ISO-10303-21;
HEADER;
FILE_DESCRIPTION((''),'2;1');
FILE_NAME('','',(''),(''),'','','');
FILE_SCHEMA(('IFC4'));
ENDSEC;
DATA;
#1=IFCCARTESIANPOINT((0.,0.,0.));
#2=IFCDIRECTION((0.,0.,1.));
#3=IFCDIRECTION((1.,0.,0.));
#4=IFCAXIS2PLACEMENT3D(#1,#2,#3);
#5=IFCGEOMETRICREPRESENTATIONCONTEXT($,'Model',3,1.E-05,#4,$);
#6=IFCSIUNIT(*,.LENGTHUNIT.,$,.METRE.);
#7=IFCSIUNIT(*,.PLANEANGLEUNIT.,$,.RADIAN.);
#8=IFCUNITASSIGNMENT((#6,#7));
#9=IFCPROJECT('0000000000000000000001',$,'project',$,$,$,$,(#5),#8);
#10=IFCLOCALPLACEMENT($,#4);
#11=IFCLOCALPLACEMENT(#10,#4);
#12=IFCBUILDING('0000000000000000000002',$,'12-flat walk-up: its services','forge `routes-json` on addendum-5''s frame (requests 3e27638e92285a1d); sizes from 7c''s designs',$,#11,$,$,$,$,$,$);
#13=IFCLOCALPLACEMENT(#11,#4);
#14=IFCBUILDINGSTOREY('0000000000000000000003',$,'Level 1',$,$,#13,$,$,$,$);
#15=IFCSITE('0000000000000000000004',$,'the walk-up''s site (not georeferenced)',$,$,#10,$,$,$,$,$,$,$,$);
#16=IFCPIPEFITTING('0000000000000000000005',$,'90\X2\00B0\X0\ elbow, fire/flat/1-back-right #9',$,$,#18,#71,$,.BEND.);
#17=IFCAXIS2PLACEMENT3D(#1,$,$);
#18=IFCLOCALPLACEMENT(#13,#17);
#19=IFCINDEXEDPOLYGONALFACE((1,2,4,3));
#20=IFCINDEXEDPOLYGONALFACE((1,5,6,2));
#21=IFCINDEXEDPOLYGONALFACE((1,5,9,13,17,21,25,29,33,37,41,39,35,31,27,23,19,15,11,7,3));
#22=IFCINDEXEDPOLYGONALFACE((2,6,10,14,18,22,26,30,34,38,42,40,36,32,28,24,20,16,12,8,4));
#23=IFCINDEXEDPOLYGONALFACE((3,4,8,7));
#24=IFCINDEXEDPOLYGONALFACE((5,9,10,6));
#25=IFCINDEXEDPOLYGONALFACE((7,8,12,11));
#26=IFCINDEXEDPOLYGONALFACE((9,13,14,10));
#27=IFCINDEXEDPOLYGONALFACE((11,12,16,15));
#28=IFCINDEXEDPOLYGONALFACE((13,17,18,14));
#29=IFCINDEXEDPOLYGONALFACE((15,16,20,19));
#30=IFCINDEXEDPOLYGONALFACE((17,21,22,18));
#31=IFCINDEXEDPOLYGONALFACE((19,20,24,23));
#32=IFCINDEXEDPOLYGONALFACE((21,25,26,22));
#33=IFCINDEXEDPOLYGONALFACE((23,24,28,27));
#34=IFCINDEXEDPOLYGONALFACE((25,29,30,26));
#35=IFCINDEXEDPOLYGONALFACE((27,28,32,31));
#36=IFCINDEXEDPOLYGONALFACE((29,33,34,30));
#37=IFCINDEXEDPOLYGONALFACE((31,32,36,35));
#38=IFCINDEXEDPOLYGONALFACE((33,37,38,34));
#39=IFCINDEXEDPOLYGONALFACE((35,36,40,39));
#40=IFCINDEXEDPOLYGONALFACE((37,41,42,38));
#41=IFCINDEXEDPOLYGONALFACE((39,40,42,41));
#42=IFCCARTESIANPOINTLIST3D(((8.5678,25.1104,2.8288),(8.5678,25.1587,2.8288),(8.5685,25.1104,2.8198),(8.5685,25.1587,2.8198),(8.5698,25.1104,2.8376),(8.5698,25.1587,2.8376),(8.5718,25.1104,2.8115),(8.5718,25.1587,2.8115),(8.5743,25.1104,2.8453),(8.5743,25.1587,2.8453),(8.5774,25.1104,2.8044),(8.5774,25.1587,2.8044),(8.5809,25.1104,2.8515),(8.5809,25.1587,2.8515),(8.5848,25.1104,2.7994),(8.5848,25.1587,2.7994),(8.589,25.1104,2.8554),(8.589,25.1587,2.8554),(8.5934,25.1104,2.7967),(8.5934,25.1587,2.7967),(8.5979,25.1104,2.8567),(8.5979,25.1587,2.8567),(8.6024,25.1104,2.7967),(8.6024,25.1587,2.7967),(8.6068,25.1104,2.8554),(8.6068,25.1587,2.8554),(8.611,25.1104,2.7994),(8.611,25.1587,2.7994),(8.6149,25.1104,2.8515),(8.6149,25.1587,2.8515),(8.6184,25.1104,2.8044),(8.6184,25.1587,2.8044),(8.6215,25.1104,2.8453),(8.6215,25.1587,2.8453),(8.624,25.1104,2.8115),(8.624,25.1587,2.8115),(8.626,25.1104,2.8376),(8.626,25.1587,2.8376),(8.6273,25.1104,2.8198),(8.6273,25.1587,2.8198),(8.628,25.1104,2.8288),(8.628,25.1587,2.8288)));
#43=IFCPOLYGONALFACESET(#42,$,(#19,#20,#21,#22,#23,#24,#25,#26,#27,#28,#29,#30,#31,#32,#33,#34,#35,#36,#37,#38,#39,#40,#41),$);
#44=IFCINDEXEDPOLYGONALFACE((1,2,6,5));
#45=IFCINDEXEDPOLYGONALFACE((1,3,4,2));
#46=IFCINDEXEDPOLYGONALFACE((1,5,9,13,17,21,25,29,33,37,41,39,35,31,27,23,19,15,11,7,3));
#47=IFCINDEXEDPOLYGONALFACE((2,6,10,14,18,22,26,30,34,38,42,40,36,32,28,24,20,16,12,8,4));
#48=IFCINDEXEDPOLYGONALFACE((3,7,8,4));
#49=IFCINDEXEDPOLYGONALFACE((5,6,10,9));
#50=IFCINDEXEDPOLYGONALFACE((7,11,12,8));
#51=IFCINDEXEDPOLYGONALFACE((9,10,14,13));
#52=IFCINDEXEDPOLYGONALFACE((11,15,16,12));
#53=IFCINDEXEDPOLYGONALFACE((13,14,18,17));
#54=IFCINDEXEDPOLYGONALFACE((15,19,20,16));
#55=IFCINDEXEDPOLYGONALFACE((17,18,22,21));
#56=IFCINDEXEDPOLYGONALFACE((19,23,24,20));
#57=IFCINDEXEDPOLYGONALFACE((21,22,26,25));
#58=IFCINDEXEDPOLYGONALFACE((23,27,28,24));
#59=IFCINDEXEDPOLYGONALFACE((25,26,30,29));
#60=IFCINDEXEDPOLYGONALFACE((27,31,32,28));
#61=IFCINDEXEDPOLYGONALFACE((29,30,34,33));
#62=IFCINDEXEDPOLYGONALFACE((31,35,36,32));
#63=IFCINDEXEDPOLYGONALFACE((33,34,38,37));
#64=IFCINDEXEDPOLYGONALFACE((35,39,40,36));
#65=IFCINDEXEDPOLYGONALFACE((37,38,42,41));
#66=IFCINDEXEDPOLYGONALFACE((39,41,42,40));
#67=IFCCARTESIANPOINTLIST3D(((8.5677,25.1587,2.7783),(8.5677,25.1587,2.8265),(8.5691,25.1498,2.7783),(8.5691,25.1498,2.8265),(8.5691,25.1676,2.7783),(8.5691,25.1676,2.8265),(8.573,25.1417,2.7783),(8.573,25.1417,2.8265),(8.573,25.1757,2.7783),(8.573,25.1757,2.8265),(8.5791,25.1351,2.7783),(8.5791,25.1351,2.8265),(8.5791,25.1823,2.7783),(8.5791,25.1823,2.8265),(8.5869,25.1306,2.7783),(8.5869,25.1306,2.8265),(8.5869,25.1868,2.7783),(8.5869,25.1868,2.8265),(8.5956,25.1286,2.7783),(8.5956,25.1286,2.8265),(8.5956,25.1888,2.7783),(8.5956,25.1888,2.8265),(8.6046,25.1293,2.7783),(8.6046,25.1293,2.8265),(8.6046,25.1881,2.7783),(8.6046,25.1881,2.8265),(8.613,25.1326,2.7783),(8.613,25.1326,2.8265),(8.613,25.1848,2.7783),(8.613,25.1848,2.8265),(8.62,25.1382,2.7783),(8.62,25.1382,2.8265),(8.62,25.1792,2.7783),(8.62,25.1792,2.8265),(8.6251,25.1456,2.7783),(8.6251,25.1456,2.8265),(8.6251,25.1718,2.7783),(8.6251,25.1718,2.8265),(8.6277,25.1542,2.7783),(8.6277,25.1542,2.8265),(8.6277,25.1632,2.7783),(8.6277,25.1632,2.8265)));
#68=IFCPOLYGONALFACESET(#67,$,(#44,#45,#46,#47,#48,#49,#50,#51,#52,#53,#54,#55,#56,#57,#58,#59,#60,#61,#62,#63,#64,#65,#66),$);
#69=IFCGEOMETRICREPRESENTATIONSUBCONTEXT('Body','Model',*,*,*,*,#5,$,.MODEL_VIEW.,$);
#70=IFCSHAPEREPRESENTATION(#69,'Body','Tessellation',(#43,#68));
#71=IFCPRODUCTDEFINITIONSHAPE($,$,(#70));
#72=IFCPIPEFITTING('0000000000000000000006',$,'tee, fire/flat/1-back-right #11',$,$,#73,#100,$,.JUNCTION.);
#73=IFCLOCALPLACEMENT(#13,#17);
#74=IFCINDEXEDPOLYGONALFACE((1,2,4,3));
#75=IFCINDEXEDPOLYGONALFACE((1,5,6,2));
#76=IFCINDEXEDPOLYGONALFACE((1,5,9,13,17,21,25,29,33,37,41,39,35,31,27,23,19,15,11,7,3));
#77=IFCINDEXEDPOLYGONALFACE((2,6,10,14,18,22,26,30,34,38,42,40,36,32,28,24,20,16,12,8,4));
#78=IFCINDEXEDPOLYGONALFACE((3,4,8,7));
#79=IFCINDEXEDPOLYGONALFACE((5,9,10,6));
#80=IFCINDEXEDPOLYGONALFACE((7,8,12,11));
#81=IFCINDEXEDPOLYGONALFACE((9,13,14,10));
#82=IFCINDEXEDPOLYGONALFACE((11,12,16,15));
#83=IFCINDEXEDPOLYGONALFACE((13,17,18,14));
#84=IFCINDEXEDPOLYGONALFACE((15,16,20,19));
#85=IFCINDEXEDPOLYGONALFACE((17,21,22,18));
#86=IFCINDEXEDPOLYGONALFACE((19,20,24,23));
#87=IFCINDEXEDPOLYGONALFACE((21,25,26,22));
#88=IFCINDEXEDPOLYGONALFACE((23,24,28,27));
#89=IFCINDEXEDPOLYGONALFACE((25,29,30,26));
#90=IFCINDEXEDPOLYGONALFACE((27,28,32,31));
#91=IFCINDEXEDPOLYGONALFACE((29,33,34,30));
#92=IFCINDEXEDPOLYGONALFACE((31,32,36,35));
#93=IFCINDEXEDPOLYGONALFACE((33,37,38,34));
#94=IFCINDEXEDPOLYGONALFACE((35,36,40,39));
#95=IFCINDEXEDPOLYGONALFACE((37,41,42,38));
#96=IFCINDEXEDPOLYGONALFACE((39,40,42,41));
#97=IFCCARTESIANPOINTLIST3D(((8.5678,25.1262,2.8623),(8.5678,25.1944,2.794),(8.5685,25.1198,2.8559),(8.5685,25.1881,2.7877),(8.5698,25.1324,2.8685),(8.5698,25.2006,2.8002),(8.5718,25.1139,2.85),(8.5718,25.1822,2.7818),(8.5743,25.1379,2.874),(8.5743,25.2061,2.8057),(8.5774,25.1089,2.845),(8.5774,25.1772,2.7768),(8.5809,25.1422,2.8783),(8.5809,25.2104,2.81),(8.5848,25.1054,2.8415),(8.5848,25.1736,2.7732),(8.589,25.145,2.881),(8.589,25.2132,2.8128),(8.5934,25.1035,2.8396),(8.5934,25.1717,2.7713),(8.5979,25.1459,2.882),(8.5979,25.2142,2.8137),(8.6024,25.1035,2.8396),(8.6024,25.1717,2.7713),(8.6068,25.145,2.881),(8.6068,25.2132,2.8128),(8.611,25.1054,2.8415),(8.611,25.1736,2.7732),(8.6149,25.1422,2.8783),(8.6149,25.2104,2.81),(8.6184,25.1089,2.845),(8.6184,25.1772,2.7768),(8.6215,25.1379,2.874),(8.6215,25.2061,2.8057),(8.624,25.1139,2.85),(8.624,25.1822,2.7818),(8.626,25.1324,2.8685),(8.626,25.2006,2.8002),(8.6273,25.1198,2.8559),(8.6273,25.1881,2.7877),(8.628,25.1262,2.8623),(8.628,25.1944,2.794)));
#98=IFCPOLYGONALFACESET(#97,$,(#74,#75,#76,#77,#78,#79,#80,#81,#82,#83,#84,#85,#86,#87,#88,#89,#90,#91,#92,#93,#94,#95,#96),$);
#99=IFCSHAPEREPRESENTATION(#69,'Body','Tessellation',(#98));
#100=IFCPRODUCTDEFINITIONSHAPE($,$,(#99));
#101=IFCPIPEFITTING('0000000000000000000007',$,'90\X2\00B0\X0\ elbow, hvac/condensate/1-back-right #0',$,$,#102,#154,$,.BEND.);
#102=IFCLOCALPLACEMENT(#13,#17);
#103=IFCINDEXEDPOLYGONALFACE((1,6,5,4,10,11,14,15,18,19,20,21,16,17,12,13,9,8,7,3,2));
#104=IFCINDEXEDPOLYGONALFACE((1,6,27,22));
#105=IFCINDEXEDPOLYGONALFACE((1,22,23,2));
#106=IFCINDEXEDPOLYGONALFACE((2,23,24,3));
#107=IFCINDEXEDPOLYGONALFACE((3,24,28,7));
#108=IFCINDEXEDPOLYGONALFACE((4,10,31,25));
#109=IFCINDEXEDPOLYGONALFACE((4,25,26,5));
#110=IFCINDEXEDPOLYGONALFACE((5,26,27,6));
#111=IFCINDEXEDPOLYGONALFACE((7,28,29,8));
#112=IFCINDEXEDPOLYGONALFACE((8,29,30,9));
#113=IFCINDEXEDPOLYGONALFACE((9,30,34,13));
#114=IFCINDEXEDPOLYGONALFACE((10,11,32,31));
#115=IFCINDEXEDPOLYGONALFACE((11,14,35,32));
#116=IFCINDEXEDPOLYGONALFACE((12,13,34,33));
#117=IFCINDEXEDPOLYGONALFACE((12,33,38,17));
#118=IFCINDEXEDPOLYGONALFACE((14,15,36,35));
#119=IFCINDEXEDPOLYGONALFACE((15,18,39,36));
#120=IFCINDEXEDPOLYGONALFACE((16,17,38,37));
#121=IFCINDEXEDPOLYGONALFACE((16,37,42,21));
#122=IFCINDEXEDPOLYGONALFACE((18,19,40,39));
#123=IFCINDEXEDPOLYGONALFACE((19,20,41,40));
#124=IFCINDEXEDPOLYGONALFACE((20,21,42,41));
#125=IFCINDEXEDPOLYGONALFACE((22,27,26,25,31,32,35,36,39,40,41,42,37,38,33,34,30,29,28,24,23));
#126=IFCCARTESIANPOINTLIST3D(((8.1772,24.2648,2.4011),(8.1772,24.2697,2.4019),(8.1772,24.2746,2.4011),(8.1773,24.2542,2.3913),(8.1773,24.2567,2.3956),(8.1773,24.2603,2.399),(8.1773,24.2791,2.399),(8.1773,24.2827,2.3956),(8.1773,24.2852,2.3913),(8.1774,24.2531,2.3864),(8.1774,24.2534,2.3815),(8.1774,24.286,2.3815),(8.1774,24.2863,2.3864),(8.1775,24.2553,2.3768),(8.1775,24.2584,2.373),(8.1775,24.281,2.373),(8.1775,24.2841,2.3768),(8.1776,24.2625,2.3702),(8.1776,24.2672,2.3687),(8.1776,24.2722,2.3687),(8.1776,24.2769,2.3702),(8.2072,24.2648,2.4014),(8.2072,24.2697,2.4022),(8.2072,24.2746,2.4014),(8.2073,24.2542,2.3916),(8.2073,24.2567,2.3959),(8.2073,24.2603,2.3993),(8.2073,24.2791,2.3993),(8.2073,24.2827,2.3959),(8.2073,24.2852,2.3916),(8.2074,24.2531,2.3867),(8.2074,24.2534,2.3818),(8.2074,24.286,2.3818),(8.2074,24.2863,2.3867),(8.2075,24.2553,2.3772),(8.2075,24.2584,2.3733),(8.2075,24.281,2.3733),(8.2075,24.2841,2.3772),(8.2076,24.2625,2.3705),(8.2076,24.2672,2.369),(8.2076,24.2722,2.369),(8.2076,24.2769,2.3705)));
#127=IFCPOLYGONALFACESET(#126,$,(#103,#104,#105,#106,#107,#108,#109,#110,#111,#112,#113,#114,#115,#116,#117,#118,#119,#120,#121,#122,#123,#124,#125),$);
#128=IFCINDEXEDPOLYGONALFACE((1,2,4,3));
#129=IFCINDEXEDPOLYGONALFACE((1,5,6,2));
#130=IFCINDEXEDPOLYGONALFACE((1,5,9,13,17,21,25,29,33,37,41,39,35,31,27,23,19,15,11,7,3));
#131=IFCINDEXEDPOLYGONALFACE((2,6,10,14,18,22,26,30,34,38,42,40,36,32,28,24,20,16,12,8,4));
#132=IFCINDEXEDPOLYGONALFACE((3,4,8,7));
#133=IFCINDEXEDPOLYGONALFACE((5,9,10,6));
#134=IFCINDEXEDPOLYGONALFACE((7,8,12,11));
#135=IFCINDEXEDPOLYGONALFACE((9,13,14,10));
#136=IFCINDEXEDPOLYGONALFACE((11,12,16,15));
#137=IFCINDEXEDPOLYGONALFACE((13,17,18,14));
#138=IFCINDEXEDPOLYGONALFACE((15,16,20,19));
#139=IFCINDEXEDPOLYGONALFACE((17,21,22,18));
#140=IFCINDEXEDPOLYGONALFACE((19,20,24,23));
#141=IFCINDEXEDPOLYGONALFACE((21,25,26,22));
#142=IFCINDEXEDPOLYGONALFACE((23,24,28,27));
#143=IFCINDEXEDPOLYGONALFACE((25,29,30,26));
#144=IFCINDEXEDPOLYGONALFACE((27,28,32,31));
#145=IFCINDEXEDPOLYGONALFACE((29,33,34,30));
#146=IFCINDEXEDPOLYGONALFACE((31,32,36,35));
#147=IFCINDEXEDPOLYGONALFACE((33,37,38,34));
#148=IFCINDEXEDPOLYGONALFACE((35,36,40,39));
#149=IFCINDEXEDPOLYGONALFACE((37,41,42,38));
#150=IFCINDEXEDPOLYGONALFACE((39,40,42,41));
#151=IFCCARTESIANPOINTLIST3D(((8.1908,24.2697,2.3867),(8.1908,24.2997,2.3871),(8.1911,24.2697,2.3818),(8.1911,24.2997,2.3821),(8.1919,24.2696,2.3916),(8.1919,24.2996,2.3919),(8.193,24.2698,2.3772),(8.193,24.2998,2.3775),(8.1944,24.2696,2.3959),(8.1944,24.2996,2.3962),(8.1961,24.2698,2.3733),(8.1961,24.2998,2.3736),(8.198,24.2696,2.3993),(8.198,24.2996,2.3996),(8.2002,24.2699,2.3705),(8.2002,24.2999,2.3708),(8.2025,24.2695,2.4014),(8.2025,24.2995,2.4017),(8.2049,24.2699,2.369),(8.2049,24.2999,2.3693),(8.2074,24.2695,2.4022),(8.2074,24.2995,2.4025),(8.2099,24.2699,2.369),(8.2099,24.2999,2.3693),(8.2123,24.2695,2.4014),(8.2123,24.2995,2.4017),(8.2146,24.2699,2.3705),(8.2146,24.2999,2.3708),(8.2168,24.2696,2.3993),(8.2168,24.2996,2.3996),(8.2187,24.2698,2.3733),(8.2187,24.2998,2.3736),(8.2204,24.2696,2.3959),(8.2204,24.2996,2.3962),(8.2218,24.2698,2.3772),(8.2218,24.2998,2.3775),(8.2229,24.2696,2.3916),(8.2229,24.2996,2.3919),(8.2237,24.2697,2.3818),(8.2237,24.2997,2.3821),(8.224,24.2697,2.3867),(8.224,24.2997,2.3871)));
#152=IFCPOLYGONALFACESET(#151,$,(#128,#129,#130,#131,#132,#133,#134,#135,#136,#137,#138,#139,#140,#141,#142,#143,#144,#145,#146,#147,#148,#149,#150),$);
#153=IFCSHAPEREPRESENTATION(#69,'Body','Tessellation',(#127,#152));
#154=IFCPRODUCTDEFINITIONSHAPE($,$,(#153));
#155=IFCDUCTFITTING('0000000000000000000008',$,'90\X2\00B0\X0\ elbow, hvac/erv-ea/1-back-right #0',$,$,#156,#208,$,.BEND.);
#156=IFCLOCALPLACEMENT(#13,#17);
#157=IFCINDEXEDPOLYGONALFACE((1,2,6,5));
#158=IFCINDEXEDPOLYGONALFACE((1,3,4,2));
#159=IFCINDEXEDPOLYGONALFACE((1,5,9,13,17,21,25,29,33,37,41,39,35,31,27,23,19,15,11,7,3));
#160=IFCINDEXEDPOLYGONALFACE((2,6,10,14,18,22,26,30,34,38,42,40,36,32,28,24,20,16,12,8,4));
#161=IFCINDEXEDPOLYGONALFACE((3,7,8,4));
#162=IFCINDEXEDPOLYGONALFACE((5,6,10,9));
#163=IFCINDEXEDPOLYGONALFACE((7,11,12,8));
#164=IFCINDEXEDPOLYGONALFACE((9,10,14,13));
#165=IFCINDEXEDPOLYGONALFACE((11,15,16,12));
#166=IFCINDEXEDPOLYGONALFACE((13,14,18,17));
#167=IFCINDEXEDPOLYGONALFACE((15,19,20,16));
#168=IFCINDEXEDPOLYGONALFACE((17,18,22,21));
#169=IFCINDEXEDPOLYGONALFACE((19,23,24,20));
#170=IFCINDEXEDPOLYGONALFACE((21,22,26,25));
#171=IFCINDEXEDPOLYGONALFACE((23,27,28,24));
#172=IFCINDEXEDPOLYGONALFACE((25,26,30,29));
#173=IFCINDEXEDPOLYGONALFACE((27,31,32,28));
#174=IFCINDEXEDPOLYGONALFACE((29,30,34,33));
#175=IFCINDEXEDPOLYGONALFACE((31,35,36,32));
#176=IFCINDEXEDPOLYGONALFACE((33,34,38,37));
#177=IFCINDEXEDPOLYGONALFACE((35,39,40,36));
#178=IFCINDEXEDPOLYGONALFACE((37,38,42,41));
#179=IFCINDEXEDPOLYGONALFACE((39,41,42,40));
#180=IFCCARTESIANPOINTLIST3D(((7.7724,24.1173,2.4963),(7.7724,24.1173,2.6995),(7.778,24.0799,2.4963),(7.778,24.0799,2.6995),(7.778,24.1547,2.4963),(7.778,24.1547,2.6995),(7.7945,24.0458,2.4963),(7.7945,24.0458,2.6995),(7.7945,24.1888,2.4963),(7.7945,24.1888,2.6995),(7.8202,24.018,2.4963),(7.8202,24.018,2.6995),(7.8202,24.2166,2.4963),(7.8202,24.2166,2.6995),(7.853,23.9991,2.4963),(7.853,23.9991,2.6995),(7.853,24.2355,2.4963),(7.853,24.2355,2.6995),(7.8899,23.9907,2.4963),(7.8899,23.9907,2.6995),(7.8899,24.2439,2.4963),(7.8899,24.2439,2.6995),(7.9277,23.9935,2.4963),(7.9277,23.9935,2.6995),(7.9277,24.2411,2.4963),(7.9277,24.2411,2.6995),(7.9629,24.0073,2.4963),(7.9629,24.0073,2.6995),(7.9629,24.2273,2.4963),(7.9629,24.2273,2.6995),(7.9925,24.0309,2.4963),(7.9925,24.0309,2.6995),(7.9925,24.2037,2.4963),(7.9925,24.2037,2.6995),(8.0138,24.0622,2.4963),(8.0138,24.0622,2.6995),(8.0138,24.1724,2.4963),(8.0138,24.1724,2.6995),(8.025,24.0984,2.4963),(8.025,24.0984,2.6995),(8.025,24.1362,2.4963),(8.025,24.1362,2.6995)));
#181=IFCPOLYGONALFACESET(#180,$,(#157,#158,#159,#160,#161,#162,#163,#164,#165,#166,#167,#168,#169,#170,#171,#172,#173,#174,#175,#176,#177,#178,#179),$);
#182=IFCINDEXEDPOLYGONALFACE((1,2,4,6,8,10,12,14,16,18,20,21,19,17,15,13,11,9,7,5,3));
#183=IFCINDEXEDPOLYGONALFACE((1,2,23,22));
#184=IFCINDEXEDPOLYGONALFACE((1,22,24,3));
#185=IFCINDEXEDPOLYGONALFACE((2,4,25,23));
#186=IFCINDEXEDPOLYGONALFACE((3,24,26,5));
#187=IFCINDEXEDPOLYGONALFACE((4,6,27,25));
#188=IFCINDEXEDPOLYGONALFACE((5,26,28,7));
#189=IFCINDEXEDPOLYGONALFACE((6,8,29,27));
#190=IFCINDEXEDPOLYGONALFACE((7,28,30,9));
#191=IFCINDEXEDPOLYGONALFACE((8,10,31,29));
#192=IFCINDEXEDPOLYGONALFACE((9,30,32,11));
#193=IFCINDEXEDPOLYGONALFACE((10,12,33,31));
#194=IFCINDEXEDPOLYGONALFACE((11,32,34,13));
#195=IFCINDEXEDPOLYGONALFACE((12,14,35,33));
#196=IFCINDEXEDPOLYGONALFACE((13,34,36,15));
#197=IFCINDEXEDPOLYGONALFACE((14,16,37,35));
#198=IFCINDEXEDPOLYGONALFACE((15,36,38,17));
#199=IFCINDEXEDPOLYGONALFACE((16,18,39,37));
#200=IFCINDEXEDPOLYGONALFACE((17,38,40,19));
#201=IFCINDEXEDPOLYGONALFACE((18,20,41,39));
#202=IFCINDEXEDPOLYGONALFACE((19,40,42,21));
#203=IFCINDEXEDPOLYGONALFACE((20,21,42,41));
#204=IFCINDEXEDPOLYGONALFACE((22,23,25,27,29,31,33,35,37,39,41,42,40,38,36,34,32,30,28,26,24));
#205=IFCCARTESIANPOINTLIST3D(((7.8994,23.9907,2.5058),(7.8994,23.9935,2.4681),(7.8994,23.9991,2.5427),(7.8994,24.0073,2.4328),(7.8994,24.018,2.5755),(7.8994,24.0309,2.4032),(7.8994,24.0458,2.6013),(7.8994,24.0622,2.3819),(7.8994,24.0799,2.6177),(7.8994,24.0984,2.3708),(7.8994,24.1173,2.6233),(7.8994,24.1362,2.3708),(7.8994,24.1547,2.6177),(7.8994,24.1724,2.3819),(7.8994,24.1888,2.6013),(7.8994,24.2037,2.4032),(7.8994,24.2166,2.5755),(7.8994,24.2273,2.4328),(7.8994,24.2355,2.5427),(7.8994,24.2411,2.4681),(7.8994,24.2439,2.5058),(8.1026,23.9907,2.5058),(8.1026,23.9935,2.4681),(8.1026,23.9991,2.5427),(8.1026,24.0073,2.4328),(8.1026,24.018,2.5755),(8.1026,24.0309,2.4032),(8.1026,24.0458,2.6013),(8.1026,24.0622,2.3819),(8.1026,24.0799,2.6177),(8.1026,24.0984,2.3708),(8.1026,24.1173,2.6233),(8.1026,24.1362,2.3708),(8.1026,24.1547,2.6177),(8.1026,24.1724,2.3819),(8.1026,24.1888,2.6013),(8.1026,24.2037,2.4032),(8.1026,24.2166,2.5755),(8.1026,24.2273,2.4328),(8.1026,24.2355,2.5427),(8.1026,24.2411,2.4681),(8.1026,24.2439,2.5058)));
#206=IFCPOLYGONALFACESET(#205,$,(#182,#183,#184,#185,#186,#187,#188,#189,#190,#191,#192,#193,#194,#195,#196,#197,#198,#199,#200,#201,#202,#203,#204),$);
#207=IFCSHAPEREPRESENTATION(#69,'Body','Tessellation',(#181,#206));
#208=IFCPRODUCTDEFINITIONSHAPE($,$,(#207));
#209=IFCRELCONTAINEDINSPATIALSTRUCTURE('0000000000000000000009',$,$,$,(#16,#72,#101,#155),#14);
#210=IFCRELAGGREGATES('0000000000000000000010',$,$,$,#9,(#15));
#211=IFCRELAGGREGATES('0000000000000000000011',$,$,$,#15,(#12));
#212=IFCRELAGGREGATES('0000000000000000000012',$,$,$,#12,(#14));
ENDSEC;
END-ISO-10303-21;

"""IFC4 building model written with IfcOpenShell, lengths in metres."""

from ifc_helpers import new_model, entity, si_unit, frame, origin_with_axes, place, context, subcontext, project, spatial, element, save


model = new_model("IFC4")

# Units and contexts
model_context = context("Model", 3, precision=1e-05, world=origin_with_axes())
body_context = subcontext(model_context, "Body", "Model", "MODEL_VIEW")
ifc_project = project(units=[si_unit("LENGTHUNIT", "METRE"), si_unit("PLANEANGLEUNIT", "RADIAN")], contexts=[model_context])

# Site, building, storey
site_placement = place(None, origin_with_axes())
site = spatial("IfcSite", under=ifc_project, at=site_placement, Name="the walk-up's site (not georeferenced)")
building_placement = place(site_placement, origin_with_axes())
building = spatial("IfcBuilding", under=site, at=building_placement, Name="12-flat walk-up: its services", Description="forge `routes-json` on addendum-5's frame (requests 3e27638e92285a1d); sizes from 7c's designs")
storey_placement = place(building_placement, origin_with_axes())
storey = spatial("IfcBuildingStorey", under=building, at=storey_placement, Name="Level 1")

# Pipe fittings
pipe_fitting_1_placement = place(storey_placement, frame((8.5979, 25.1104, 2.8265), z_axis=(0.0, 0.0, 1.0), x_axis=(1.0, 0.0, 0.0)))
element("IfcPipeFitting", 1, at=pipe_fitting_1_placement, inside=storey, Name="90° elbow, fire/flat/1-back-right #9", PredefinedType="BEND", context=body_context, shape_type="AdvancedSweptSolid", body=[
    entity("IfcSweptDiskSolid", entity("IfcPolyline", [entity("IfcCartesianPoint", [0.0, 0.0, 0.0]), entity("IfcCartesianPoint", [0.0, 0.0483, 0.0])]), 0.0302),
    entity("IfcSweptDiskSolid", entity("IfcPolyline", [entity("IfcCartesianPoint", [0.0, 0.0483, 0.0]), entity("IfcCartesianPoint", [0.0, 0.0483, -0.0483])]), 0.0302),
])
pipe_fitting_2_placement = place(storey_placement, frame((8.5979, 25.1246, 2.8607), z_axis=(0.0, 0.0, 1.0), x_axis=(1.0, 0.0, 0.0)))
element("IfcPipeFitting", 2, at=pipe_fitting_2_placement, inside=storey, Name="tee, fire/flat/1-back-right #11", PredefinedType="JUNCTION", context=body_context, shape_type="AdvancedSweptSolid", body=[
    entity("IfcSweptDiskSolid", entity("IfcPolyline", [entity("IfcCartesianPoint", [0.0, 0.0, 0.0]), entity("IfcCartesianPoint", [0.0, 0.0682, -0.0682])]), 0.0302),
])
pipe_fitting_3_placement = place(storey_placement, frame((8.1774, 24.2697, 2.3852), z_axis=(0.0, 0.0, 1.0), x_axis=(1.0, 0.0, 0.0)))
element("IfcPipeFitting", 3, at=pipe_fitting_3_placement, inside=storey, Name="90° elbow, hvac/condensate/1-back-right #0", PredefinedType="BEND", context=body_context, shape_type="AdvancedSweptSolid", body=[
    entity("IfcSweptDiskSolid", entity("IfcPolyline", [entity("IfcCartesianPoint", [0.0, 0.0, 0.0]), entity("IfcCartesianPoint", [0.03, 0.0, 0.0003])]), 0.0167),
    entity("IfcSweptDiskSolid", entity("IfcPolyline", [entity("IfcCartesianPoint", [0.03, 0.0, 0.0003]), entity("IfcCartesianPoint", [0.03, 0.03, 0.0006])]), 0.0167),
])

# Duct fitting
duct_fitting_1_placement = place(storey_placement, frame((7.8994, 24.1173, 2.6995), z_axis=(0.0, 0.0, 1.0), x_axis=(1.0, 0.0, 0.0)))
element("IfcDuctFitting", 4, at=duct_fitting_1_placement, inside=storey, Name="90° elbow, hvac/erv-ea/1-back-right #0", PredefinedType="BEND", context=body_context, shape_type="AdvancedSweptSolid", body=[
    entity("IfcSweptDiskSolid", entity("IfcPolyline", [entity("IfcCartesianPoint", [0.0, 0.0, 0.0]), entity("IfcCartesianPoint", [0.0, 0.0, -0.2032])]), 0.127),
    entity("IfcSweptDiskSolid", entity("IfcPolyline", [entity("IfcCartesianPoint", [0.0, 0.0, -0.2032]), entity("IfcCartesianPoint", [0.2032, 0.0, -0.2032])]), 0.127),
])

save(model, "model.ifc")
